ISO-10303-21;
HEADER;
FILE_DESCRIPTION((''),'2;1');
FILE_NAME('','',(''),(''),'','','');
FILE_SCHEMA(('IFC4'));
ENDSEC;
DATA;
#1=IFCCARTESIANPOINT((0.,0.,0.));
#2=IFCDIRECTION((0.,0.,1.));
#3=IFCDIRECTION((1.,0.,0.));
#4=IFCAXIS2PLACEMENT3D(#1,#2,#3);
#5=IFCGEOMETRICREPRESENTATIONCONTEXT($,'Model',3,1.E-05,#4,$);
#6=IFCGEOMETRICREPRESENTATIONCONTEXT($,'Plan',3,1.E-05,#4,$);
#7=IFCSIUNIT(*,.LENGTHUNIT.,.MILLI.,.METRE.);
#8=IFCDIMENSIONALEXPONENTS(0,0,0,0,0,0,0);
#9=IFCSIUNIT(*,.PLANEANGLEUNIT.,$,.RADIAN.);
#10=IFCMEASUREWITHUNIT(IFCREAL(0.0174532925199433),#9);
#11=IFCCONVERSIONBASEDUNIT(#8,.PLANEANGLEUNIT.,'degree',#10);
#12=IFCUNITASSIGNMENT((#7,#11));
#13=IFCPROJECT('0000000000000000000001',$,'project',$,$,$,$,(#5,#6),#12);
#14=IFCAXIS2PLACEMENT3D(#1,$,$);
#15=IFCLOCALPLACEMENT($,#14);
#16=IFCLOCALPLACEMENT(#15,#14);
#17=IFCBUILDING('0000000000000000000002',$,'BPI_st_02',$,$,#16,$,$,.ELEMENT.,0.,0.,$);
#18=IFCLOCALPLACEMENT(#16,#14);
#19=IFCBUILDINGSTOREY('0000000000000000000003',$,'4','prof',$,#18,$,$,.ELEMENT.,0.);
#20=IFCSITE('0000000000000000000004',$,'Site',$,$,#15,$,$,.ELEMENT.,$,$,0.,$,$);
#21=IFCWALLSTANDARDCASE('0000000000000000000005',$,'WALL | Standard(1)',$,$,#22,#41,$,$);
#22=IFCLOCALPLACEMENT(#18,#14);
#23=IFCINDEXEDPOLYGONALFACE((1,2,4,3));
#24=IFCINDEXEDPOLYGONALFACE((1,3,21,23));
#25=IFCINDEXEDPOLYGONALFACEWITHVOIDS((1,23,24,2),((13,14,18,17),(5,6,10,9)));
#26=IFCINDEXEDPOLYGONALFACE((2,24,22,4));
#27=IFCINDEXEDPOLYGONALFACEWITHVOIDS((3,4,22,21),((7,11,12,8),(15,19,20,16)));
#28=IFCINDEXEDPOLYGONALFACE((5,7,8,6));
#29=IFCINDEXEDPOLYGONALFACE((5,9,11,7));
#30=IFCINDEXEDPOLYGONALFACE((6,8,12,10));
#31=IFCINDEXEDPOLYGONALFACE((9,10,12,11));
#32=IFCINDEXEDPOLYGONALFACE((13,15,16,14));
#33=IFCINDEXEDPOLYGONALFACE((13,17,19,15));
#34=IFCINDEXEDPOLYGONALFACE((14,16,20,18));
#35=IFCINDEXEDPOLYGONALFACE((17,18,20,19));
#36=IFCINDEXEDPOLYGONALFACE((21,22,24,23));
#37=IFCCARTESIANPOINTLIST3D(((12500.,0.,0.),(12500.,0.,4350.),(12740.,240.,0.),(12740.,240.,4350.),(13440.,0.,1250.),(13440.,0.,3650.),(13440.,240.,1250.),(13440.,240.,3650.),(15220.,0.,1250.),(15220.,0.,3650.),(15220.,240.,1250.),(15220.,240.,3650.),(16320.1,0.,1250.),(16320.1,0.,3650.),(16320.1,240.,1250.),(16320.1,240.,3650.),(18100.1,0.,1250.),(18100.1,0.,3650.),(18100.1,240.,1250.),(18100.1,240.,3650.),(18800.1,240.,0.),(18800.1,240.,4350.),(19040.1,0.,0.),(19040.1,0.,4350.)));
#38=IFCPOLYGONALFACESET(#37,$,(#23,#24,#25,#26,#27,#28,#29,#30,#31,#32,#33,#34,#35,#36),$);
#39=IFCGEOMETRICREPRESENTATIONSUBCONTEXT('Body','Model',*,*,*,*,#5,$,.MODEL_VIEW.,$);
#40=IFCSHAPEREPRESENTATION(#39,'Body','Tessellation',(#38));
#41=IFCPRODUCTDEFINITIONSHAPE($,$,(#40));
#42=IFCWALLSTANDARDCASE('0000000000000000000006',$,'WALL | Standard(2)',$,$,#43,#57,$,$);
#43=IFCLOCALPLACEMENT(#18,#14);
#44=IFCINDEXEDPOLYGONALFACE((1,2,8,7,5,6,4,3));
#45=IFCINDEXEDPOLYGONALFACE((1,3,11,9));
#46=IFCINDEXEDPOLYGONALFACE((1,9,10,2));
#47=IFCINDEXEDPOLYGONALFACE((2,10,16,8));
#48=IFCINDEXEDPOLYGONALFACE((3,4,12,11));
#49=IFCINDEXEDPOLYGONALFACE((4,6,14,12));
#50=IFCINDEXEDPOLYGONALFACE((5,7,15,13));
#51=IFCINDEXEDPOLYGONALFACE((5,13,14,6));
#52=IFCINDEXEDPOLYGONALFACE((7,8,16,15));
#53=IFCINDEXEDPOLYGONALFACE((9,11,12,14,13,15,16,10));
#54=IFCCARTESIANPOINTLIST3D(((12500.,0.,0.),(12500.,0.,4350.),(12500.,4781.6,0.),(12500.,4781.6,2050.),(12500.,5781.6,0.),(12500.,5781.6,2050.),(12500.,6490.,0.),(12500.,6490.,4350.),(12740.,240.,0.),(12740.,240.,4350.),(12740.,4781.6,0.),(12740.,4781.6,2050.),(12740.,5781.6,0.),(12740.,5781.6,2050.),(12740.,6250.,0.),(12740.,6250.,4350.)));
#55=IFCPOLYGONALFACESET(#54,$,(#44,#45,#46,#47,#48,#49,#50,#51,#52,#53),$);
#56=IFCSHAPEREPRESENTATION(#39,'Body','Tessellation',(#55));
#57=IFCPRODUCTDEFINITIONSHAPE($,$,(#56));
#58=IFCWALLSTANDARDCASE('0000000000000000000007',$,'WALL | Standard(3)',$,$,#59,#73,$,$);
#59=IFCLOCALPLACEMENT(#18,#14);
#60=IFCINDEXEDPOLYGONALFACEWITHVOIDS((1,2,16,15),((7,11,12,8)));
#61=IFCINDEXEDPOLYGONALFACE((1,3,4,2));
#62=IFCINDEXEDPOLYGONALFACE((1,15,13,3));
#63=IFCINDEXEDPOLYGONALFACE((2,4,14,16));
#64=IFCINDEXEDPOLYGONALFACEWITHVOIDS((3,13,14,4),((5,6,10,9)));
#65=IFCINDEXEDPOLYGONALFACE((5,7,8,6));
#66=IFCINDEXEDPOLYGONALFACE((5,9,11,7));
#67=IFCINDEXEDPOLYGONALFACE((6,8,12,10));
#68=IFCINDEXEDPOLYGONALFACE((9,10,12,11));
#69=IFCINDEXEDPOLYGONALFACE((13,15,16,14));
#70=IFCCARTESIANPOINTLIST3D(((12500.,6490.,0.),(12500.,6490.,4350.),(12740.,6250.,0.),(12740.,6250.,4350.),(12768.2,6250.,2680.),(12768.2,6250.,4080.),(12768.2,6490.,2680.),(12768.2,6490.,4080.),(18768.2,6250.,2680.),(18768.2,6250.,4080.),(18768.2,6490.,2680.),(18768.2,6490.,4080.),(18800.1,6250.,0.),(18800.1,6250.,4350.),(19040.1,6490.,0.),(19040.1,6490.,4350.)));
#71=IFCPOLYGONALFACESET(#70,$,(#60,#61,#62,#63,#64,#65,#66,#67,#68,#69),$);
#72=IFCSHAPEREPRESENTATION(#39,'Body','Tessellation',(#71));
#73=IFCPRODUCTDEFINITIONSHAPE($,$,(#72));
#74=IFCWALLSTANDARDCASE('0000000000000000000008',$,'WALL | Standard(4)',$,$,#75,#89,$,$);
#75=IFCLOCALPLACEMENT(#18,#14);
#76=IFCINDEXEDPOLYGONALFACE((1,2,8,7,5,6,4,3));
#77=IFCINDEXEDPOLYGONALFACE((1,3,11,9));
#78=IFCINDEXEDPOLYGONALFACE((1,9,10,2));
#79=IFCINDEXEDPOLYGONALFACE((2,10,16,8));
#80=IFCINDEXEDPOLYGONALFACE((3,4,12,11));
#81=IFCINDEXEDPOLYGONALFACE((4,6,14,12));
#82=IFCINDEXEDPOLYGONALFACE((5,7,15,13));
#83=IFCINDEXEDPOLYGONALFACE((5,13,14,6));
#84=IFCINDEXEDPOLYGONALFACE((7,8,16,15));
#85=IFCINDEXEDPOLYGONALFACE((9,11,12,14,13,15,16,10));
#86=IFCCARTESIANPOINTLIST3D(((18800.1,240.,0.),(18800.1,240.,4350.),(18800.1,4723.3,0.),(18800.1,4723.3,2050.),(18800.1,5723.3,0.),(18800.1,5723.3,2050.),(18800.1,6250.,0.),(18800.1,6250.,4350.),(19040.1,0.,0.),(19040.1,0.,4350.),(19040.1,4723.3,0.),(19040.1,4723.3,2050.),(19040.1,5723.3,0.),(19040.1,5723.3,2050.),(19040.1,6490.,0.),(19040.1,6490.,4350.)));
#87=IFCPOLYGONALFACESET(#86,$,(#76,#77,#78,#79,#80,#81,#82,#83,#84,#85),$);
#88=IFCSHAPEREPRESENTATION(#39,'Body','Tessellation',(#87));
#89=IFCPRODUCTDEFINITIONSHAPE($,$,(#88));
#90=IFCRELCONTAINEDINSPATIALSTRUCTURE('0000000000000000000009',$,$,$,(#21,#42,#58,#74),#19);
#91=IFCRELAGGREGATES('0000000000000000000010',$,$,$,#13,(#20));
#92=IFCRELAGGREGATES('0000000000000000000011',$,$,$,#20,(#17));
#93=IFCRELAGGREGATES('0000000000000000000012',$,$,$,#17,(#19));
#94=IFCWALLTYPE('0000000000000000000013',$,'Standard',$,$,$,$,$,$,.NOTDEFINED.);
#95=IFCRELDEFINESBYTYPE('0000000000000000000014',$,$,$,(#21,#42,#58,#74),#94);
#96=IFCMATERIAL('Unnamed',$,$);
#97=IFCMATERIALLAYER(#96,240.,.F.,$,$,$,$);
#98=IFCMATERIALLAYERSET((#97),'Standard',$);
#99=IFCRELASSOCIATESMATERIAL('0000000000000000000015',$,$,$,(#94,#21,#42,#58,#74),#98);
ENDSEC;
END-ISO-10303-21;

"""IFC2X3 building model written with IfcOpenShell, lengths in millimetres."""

from ifc_helpers import new_model, entity, si_unit, converted_unit, frame, origin, origin_with_axes, origin_2d_with_axis, place, context, subcontext, project, spatial, polyline, segment, composite_curve, rectangle, outline, extrude, material, layer, layer_set, layer_usage, type_object, element, save


model = new_model("IFC2X3")

# Units and contexts
model_context = context("Model", 3, precision=1e-05, world=origin_with_axes())
plan_context = context("Plan", 3, precision=1e-05, world=origin_with_axes())
body_context = subcontext(model_context, "Body", "Model", "MODEL_VIEW")
ifc_project = project(units=[si_unit("LENGTHUNIT", "METRE", prefix="MILLI"), converted_unit("PLANEANGLEUNIT", "degree", entity("IfcReal", 0.0174532925199433), si_unit("PLANEANGLEUNIT", "RADIAN"), dimensions=[0, 0, 0, 0, 0, 0, 0])], contexts=[model_context, plan_context])

# Site, building, storey
site_placement = place(None, origin())
site = spatial("IfcSite", under=ifc_project, at=site_placement, Name="Site", CompositionType="ELEMENT", RefElevation=0.0)
building_placement = place(site_placement, origin())
building = spatial("IfcBuilding", under=site, at=building_placement, Name="BPI_st_02", CompositionType="ELEMENT", ElevationOfRefHeight=0.0, ElevationOfTerrain=0.0)
storey_placement = place(building_placement, origin())
storey = spatial("IfcBuildingStorey", under=building, at=storey_placement, Name="4", Description="prof", CompositionType="ELEMENT", Elevation=0.0)

# Shared definitions
ifc_material = material(Name="Unnamed")

# Wall, openings
ifc_layer_1 = layer(ifc_material, 240.0, ventilated=False)
ifc_layer_set_1 = layer_set([ifc_layer_1], Name="Standard")
ifc_layer_usage_1 = layer_usage(ifc_layer_set_1, "AXIS2", "POSITIVE", -120.0)
wall_type = type_object("IfcWallType", Name="Standard", PredefinedType="NOTDEFINED", material=ifc_layer_set_1)
wall_1_placement = place(storey_placement, frame((18920.1, 120.0, 0.0), z_axis=(0.0, 0.0, 1.0), x_axis=(-1.0, 0.0, 0.0)))
wall_1 = element("IfcWallStandardCase", 1, at=wall_1_placement, inside=storey, type_object=wall_type, material=ifc_layer_usage_1, Name="WALL | Standard(1)", context=body_context, shape_type="SweptSolid", body=[
    extrude(outline(composite_curve([segment(polyline([(-120.0, 120.0), (120.0, -120.0)]), True, "CONTINUOUS"), segment(polyline([(120.0, -120.0), (6180.0, -120.0)]), True, "CONTINUOUS"), segment(polyline([(6180.0, -120.0), (6420.0, 120.0)]), True, "CONTINUOUS"), segment(polyline([(6420.0, 120.0), (-120.0, 120.0)]), True, "CONTINUOUS")], self_intersect=False)), origin(), (0.0, 0.0, 1.0), 4350.0),
])
opening_1_placement = place(wall_1_placement, frame((3700.0, 0.0, 1250.0)))
element("IfcOpeningElement", 2, at=opening_1_placement, cuts=wall_1, context=body_context, shape_type="SweptSolid", body=[
    extrude(rectangle(XDim=1780.0, YDim=2400.0, at=origin_2d_with_axis()), frame((890.0, 120.0, 1200.0), z_axis=(0.0, -1.0, 0.0), x_axis=(1.0, 0.0, 0.0)), (0.0, 0.0, 1.0), 240.0),
])
opening_2_placement = place(wall_1_placement, frame((820.0, 0.0, 1250.0)))
element("IfcOpeningElement", 3, at=opening_2_placement, cuts=wall_1, context=body_context, shape_type="SweptSolid", body=[
    extrude(rectangle(XDim=1780.0, YDim=2400.0, at=origin_2d_with_axis()), frame((890.0, 120.0, 1200.0), z_axis=(0.0, -1.0, 0.0), x_axis=(1.0, 0.0, 0.0)), (0.0, 0.0, 1.0), 240.0),
])

# Walls, openings
ifc_layer_usage_2 = layer_usage(ifc_layer_set_1, "AXIS2", "POSITIVE", -120.0)
wall_2_placement = place(storey_placement, frame((12620.0, 6370.0, 0.0), z_axis=(0.0, 0.0, 1.0), x_axis=(0.0, -1.0, 0.0)))
wall_2 = element("IfcWallStandardCase", 4, at=wall_2_placement, inside=storey, type_object=wall_type, material=ifc_layer_usage_2, Name="WALL | Standard(2)", context=body_context, shape_type="SweptSolid", body=[
    extrude(outline(composite_curve([segment(polyline([(120.0, 120.0), (-120.0, -120.0)]), True, "CONTINUOUS"), segment(polyline([(-120.0, -120.0), (6370.0, -120.0)]), True, "CONTINUOUS"), segment(polyline([(6370.0, -120.0), (6130.0, 120.0)]), True, "CONTINUOUS"), segment(polyline([(6130.0, 120.0), (120.0, 120.0)]), True, "CONTINUOUS")], self_intersect=False)), origin(), (0.0, 0.0, 1.0), 4350.0),
])
opening_3_placement = place(wall_2_placement, frame((588.4, 0.0, 0.0)))
element("IfcOpeningElement", 5, at=opening_3_placement, cuts=wall_2, context=body_context, shape_type="SweptSolid", body=[
    extrude(rectangle(XDim=1000.0, YDim=2050.0, at=origin_2d_with_axis()), frame((500.0, 120.0, 1025.0), z_axis=(0.0, -1.0, 0.0), x_axis=(1.0, 0.0, 0.0)), (0.0, 0.0, 1.0), 240.0),
])
ifc_layer_usage_3 = layer_usage(ifc_layer_set_1, "AXIS2", "POSITIVE", -120.0)
wall_3_placement = place(storey_placement, frame((12620.0, 6370.0, 0.0)))
wall_3 = element("IfcWallStandardCase", 6, at=wall_3_placement, inside=storey, type_object=wall_type, material=ifc_layer_usage_3, Name="WALL | Standard(3)", context=body_context, shape_type="SweptSolid", body=[
    extrude(outline(composite_curve([segment(polyline([(-120.0, 120.0), (120.0, -120.0)]), True, "CONTINUOUS"), segment(polyline([(120.0, -120.0), (6180.0, -120.0)]), True, "CONTINUOUS"), segment(polyline([(6180.0, -120.0), (6420.0, 120.0)]), True, "CONTINUOUS"), segment(polyline([(6420.0, 120.0), (-120.0, 120.0)]), True, "CONTINUOUS")], self_intersect=False)), origin(), (0.0, 0.0, 1.0), 4350.0),
])
opening_4_placement = place(wall_3_placement, frame((148.2, 0.0, 2680.0)))
element("IfcOpeningElement", 7, at=opening_4_placement, cuts=wall_3, context=body_context, shape_type="SweptSolid", body=[
    extrude(rectangle(XDim=6000.0, YDim=1400.0, at=origin_2d_with_axis()), frame((3000.0, 120.0, 700.0), z_axis=(0.0, -1.0, 0.0), x_axis=(1.0, 0.0, 0.0)), (0.0, 0.0, 1.0), 240.0),
])
ifc_layer_usage_4 = layer_usage(ifc_layer_set_1, "AXIS2", "POSITIVE", -120.0)
wall_4_placement = place(storey_placement, frame((18920.1, 6370.0, 0.0), z_axis=(0.0, 0.0, 1.0), x_axis=(0.0, -1.0, 0.0)))
wall_4 = element("IfcWallStandardCase", 8, at=wall_4_placement, inside=storey, type_object=wall_type, material=ifc_layer_usage_4, Name="WALL | Standard(4)", context=body_context, shape_type="SweptSolid", body=[
    extrude(outline(composite_curve([segment(polyline([(-120.0, 120.0), (120.0, -120.0)]), True, "CONTINUOUS"), segment(polyline([(120.0, -120.0), (6130.0, -120.0)]), True, "CONTINUOUS"), segment(polyline([(6130.0, -120.0), (6370.0, 120.0)]), True, "CONTINUOUS"), segment(polyline([(6370.0, 120.0), (-120.0, 120.0)]), True, "CONTINUOUS")], self_intersect=False)), origin(), (0.0, 0.0, 1.0), 4350.0),
])
opening_5_placement = place(wall_4_placement, frame((646.6, 0.0, 0.0)))
element("IfcOpeningElement", 9, at=opening_5_placement, cuts=wall_4, context=body_context, shape_type="SweptSolid", body=[
    extrude(rectangle(XDim=1000.0, YDim=2050.0, at=origin_2d_with_axis()), frame((500.0, 120.0, 1025.0), z_axis=(0.0, -1.0, 0.0), x_axis=(1.0, 0.0, 0.0)), (0.0, 0.0, 1.0), 240.0),
])

save(model, "model.ifc")
